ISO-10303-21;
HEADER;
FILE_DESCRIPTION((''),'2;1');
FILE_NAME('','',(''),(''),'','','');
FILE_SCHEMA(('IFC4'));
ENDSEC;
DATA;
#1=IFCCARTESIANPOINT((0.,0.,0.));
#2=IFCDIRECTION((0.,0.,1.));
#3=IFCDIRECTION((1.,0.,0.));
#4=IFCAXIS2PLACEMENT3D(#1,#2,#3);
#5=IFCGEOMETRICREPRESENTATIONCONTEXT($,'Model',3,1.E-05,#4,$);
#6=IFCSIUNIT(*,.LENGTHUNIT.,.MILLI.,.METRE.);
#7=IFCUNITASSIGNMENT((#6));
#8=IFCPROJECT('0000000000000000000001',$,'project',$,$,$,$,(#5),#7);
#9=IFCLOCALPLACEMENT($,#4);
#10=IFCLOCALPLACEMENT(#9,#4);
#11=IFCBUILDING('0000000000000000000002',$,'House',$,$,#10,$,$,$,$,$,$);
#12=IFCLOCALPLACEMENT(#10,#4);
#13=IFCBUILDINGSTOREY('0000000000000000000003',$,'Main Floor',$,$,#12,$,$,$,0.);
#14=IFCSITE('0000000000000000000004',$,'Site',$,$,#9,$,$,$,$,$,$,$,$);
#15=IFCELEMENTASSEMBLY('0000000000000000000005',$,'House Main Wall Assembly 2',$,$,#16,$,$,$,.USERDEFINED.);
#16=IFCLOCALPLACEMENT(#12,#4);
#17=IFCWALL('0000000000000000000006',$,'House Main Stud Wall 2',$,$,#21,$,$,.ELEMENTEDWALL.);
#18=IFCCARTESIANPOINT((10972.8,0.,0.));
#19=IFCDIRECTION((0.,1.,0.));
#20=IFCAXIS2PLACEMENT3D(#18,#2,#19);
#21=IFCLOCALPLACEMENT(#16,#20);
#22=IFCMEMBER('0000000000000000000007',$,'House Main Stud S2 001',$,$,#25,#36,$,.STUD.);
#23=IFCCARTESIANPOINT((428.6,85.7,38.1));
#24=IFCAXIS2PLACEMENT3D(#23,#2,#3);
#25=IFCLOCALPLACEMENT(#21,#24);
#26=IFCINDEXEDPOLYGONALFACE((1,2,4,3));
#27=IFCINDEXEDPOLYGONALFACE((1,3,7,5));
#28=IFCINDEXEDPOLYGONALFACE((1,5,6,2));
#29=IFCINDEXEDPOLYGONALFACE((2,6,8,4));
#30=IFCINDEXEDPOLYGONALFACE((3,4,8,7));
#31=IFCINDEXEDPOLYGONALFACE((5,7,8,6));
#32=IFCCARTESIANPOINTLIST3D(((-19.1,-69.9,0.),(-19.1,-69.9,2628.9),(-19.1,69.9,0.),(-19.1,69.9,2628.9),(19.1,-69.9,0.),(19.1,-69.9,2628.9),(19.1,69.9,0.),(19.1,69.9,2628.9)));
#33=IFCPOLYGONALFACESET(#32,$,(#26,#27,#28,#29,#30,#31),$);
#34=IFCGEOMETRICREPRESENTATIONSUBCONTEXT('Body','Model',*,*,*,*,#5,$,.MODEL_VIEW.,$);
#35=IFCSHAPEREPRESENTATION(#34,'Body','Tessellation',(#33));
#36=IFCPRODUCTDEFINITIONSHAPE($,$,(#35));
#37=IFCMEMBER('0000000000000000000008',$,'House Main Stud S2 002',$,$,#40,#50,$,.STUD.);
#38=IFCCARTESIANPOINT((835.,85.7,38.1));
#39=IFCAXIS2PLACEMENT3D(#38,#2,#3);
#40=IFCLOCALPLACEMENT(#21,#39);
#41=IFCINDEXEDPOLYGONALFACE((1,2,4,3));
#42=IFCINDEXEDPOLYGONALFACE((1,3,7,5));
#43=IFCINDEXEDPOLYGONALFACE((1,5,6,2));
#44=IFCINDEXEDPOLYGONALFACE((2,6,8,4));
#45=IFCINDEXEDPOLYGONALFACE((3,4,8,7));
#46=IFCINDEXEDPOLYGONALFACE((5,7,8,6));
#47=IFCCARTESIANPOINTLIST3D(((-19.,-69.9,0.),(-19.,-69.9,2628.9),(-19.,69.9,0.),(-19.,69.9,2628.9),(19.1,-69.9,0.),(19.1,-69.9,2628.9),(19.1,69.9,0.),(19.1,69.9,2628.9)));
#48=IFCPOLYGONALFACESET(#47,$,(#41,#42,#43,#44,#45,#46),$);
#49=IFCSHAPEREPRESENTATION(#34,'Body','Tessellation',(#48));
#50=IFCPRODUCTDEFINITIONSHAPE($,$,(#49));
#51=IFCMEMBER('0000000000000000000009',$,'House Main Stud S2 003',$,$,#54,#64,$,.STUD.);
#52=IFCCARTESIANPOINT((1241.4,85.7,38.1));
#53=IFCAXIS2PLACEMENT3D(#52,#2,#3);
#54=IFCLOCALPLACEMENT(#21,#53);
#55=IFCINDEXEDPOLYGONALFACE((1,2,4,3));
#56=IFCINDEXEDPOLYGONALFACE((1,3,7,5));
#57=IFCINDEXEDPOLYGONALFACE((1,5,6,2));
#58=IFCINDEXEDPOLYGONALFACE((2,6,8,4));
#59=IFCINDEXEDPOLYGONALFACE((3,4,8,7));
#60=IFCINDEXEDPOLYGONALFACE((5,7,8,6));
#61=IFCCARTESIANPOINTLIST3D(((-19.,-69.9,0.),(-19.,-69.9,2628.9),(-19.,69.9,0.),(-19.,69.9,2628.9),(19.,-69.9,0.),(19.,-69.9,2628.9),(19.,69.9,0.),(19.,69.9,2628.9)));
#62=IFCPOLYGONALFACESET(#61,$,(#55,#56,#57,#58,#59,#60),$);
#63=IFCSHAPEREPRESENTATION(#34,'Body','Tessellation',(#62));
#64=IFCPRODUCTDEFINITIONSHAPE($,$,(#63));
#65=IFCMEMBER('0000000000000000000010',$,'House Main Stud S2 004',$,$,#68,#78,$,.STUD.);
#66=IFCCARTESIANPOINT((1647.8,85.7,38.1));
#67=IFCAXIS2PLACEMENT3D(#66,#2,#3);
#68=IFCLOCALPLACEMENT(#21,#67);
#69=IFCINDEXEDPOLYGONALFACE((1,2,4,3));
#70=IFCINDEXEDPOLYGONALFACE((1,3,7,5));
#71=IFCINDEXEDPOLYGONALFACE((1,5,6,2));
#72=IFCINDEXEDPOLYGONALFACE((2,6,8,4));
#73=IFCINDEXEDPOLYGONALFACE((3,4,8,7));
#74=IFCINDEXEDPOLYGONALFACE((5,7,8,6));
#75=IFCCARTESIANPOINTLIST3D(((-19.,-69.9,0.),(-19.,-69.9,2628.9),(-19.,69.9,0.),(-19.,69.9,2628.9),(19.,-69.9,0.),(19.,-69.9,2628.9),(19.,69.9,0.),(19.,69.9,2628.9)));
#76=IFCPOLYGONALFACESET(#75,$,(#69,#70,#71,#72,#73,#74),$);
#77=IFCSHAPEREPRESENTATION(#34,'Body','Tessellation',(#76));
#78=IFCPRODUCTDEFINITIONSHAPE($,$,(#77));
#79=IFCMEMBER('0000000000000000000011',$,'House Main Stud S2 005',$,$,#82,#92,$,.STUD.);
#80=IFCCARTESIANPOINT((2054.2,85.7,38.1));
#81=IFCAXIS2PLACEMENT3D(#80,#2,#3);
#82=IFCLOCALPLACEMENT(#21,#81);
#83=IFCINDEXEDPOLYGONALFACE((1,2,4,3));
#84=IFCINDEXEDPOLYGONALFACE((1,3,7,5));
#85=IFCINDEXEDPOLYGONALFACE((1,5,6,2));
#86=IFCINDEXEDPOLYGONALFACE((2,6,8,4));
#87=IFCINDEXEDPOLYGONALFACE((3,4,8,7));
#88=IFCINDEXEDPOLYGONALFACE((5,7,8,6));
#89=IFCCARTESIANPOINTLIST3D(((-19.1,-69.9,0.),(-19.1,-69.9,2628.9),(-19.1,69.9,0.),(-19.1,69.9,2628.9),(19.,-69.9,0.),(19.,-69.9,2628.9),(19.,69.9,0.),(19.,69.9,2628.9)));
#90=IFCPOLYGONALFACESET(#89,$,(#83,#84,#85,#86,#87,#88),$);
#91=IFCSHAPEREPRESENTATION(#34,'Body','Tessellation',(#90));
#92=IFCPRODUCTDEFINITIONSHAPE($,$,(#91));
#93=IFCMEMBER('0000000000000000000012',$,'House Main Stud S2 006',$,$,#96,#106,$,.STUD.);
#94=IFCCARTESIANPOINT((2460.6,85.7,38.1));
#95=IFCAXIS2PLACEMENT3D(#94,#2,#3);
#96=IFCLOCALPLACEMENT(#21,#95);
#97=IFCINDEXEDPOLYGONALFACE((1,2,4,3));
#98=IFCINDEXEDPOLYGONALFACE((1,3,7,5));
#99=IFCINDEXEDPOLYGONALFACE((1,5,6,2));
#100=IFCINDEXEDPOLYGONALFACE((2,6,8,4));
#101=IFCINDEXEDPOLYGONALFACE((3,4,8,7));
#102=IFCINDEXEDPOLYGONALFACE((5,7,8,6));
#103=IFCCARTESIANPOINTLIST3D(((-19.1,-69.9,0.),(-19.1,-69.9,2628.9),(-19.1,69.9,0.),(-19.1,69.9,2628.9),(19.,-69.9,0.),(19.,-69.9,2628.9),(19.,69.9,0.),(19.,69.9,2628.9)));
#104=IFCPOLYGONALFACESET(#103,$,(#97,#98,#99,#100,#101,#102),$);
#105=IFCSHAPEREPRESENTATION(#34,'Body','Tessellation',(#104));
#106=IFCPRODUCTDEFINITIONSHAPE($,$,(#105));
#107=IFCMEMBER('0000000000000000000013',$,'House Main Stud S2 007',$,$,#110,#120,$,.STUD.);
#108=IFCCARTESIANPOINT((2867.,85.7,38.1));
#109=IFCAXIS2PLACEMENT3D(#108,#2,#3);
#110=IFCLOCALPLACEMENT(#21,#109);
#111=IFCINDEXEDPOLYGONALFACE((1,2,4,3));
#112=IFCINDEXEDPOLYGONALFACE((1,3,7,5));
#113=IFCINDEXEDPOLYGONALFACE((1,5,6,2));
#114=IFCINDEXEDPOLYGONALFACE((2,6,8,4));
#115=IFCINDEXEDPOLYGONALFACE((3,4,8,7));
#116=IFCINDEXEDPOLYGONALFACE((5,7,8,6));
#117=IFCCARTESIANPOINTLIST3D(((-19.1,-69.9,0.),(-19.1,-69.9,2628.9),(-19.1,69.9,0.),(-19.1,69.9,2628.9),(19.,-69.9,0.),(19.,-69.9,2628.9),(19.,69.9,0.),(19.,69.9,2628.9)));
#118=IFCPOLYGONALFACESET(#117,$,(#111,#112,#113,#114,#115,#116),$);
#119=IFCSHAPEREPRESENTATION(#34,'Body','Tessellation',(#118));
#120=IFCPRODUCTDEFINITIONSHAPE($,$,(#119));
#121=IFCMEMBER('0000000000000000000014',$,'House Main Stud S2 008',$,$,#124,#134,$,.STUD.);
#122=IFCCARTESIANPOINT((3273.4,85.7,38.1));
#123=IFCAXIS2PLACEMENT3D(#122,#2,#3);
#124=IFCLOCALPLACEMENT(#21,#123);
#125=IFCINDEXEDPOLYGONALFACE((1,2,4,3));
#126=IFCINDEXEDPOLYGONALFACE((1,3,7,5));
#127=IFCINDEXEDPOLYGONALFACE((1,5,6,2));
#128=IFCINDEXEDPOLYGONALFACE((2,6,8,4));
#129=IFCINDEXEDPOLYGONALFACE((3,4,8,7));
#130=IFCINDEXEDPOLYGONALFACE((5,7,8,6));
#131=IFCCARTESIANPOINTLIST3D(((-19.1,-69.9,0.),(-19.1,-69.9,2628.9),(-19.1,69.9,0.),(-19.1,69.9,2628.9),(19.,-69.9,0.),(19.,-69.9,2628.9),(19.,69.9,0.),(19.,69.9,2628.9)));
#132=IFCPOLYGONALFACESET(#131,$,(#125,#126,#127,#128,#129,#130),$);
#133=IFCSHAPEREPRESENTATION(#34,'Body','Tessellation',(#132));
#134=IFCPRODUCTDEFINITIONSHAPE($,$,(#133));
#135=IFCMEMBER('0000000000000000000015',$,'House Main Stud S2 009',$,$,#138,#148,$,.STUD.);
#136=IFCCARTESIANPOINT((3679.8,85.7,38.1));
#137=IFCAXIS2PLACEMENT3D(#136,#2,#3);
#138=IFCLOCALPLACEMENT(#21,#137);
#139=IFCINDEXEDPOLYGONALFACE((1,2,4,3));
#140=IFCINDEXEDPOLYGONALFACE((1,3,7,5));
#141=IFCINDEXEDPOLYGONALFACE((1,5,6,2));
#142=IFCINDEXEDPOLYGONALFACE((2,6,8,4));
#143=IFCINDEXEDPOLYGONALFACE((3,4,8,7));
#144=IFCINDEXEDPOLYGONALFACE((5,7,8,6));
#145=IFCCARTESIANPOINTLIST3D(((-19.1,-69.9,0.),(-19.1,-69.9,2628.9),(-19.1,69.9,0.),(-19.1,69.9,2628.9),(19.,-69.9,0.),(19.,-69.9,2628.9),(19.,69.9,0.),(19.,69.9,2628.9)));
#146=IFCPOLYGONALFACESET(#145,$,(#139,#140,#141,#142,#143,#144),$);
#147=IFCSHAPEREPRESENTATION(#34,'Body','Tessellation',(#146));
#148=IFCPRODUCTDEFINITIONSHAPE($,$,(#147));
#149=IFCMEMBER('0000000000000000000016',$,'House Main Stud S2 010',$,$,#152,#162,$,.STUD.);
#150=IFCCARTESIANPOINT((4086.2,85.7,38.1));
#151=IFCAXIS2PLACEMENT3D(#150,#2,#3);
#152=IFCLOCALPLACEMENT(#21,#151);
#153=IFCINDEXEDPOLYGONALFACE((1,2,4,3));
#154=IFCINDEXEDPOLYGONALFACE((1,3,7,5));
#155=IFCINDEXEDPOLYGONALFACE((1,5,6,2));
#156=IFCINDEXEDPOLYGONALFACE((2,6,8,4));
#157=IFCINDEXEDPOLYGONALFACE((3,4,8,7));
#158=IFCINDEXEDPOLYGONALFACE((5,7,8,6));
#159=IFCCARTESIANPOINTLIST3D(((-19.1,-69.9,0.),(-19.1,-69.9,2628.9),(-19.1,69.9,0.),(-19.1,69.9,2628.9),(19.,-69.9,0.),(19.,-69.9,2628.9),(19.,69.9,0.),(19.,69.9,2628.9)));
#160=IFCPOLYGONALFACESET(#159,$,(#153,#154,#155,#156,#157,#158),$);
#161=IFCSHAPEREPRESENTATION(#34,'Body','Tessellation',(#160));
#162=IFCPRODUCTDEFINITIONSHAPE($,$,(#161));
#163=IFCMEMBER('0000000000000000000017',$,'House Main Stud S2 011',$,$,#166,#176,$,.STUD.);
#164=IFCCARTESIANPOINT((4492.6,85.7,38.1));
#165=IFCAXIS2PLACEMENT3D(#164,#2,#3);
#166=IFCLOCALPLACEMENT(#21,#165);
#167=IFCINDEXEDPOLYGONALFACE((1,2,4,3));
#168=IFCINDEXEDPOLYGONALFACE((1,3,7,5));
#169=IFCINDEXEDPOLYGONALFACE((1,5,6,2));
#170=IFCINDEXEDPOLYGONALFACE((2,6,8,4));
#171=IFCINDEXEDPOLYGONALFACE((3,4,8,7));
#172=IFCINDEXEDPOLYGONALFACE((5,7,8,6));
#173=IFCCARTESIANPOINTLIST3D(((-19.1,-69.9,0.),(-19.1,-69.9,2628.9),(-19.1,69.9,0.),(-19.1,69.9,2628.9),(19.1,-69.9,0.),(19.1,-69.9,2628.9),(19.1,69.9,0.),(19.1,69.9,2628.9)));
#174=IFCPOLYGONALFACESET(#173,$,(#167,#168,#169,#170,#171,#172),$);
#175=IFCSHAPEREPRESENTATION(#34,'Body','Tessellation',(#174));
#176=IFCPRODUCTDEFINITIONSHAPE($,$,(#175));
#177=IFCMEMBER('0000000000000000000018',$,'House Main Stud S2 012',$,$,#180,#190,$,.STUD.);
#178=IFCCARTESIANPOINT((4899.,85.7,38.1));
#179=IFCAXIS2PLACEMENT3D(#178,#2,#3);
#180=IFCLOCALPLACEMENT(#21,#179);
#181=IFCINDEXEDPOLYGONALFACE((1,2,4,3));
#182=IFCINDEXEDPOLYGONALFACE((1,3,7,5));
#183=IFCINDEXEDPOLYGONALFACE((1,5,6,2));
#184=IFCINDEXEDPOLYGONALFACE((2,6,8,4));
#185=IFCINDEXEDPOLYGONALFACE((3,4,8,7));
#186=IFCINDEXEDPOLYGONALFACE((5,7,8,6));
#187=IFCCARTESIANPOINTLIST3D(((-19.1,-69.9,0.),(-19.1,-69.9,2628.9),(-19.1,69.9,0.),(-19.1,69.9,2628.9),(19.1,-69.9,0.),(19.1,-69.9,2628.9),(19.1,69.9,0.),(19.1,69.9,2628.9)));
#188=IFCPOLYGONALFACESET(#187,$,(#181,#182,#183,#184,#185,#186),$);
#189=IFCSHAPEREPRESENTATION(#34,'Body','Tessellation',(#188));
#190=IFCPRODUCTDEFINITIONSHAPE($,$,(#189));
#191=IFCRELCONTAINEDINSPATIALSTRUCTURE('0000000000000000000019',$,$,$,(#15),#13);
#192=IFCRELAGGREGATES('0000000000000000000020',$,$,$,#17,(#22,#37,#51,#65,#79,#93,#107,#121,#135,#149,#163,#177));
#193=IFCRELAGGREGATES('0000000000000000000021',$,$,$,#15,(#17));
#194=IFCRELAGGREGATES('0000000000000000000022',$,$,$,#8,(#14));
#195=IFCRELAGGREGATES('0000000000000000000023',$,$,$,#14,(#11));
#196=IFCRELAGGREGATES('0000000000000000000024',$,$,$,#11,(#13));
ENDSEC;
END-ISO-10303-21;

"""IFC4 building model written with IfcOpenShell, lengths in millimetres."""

from ifc_helpers import new_model, si_unit, frame, origin_with_axes, origin_2d, place, context, subcontext, project, spatial, rectangle, extrude, element, aggregate, save


model = new_model("IFC4")

# Units and contexts
model_context = context("Model", 3, precision=1e-05, world=origin_with_axes())
body_context = subcontext(model_context, "Body", "Model", "MODEL_VIEW")
ifc_project = project(units=[si_unit("LENGTHUNIT", "METRE", prefix="MILLI")], contexts=[model_context])

# Site, building, storey
site_placement = place(None, origin_with_axes())
site = spatial("IfcSite", under=ifc_project, at=site_placement, Name="Site")
building_placement = place(site_placement, origin_with_axes())
building = spatial("IfcBuilding", under=site, at=building_placement, Name="House")
storey_placement = place(building_placement, origin_with_axes())
storey = spatial("IfcBuildingStorey", under=building, at=storey_placement, Name="Main Floor", Elevation=0.0)

# Element assembly, wall, members
assembly_1_placement = place(storey_placement, origin_with_axes())
assembly_1 = element("IfcElementAssembly", 1, at=assembly_1_placement, inside=storey, Name="House Main Wall Assembly 2", PredefinedType="USERDEFINED")
wall_1_placement = place(assembly_1_placement, frame((10972.8, 0.0, 0.0), z_axis=(0.0, 0.0, 1.0), x_axis=(0.0, 1.0, 0.0)))
wall_1 = element("IfcWall", 2, at=wall_1_placement, Name="House Main Stud Wall 2", PredefinedType="ELEMENTEDWALL")
member_1_placement = place(wall_1_placement, frame((428.6, 85.7, 38.1), z_axis=(0.0, 0.0, 1.0), x_axis=(1.0, 0.0, 0.0)))
member_1 = element("IfcMember", 3, at=member_1_placement, Name="House Main Stud S2 001", PredefinedType="STUD", context=body_context, shape_type="SweptSolid", body=[
    extrude(rectangle(XDim=38.1, YDim=139.7, at=origin_2d()), origin_with_axes(), (0.0, 0.0, 1.0), 2628.9),
])
member_2_placement = place(wall_1_placement, frame((835.0, 85.7, 38.1), z_axis=(0.0, 0.0, 1.0), x_axis=(1.0, 0.0, 0.0)))
member_2 = element("IfcMember", 4, at=member_2_placement, Name="House Main Stud S2 002", PredefinedType="STUD", context=body_context, shape_type="SweptSolid", body=[
    extrude(rectangle(XDim=38.1, YDim=139.7, at=origin_2d()), origin_with_axes(), (0.0, 0.0, 1.0), 2628.9),
])
member_3_placement = place(wall_1_placement, frame((1241.4, 85.7, 38.1), z_axis=(0.0, 0.0, 1.0), x_axis=(1.0, 0.0, 0.0)))
member_3 = element("IfcMember", 5, at=member_3_placement, Name="House Main Stud S2 003", PredefinedType="STUD", context=body_context, shape_type="SweptSolid", body=[
    extrude(rectangle(XDim=38.1, YDim=139.7, at=origin_2d()), origin_with_axes(), (0.0, 0.0, 1.0), 2628.9),
])
member_4_placement = place(wall_1_placement, frame((1647.8, 85.7, 38.1), z_axis=(0.0, 0.0, 1.0), x_axis=(1.0, 0.0, 0.0)))
member_4 = element("IfcMember", 6, at=member_4_placement, Name="House Main Stud S2 004", PredefinedType="STUD", context=body_context, shape_type="SweptSolid", body=[
    extrude(rectangle(XDim=38.1, YDim=139.7, at=origin_2d()), origin_with_axes(), (0.0, 0.0, 1.0), 2628.9),
])
member_5_placement = place(wall_1_placement, frame((2054.2, 85.7, 38.1), z_axis=(0.0, 0.0, 1.0), x_axis=(1.0, 0.0, 0.0)))
member_5 = element("IfcMember", 7, at=member_5_placement, Name="House Main Stud S2 005", PredefinedType="STUD", context=body_context, shape_type="SweptSolid", body=[
    extrude(rectangle(XDim=38.1, YDim=139.7, at=origin_2d()), origin_with_axes(), (0.0, 0.0, 1.0), 2628.9),
])
member_6_placement = place(wall_1_placement, frame((2460.6, 85.7, 38.1), z_axis=(0.0, 0.0, 1.0), x_axis=(1.0, 0.0, 0.0)))
member_6 = element("IfcMember", 8, at=member_6_placement, Name="House Main Stud S2 006", PredefinedType="STUD", context=body_context, shape_type="SweptSolid", body=[
    extrude(rectangle(XDim=38.1, YDim=139.7, at=origin_2d()), origin_with_axes(), (0.0, 0.0, 1.0), 2628.9),
])
member_7_placement = place(wall_1_placement, frame((2867.0, 85.7, 38.1), z_axis=(0.0, 0.0, 1.0), x_axis=(1.0, 0.0, 0.0)))
member_7 = element("IfcMember", 9, at=member_7_placement, Name="House Main Stud S2 007", PredefinedType="STUD", context=body_context, shape_type="SweptSolid", body=[
    extrude(rectangle(XDim=38.1, YDim=139.7, at=origin_2d()), origin_with_axes(), (0.0, 0.0, 1.0), 2628.9),
])
member_8_placement = place(wall_1_placement, frame((3273.4, 85.7, 38.1), z_axis=(0.0, 0.0, 1.0), x_axis=(1.0, 0.0, 0.0)))
member_8 = element("IfcMember", 10, at=member_8_placement, Name="House Main Stud S2 008", PredefinedType="STUD", context=body_context, shape_type="SweptSolid", body=[
    extrude(rectangle(XDim=38.1, YDim=139.7, at=origin_2d()), origin_with_axes(), (0.0, 0.0, 1.0), 2628.9),
])
member_9_placement = place(wall_1_placement, frame((3679.8, 85.7, 38.1), z_axis=(0.0, 0.0, 1.0), x_axis=(1.0, 0.0, 0.0)))
member_9 = element("IfcMember", 11, at=member_9_placement, Name="House Main Stud S2 009", PredefinedType="STUD", context=body_context, shape_type="SweptSolid", body=[
    extrude(rectangle(XDim=38.1, YDim=139.7, at=origin_2d()), origin_with_axes(), (0.0, 0.0, 1.0), 2628.9),
])
member_10_placement = place(wall_1_placement, frame((4086.2, 85.7, 38.1), z_axis=(0.0, 0.0, 1.0), x_axis=(1.0, 0.0, 0.0)))
member_10 = element("IfcMember", 12, at=member_10_placement, Name="House Main Stud S2 010", PredefinedType="STUD", context=body_context, shape_type="SweptSolid", body=[
    extrude(rectangle(XDim=38.1, YDim=139.7, at=origin_2d()), origin_with_axes(), (0.0, 0.0, 1.0), 2628.9),
])
member_11_placement = place(wall_1_placement, frame((4492.6, 85.7, 38.1), z_axis=(0.0, 0.0, 1.0), x_axis=(1.0, 0.0, 0.0)))
member_11 = element("IfcMember", 13, at=member_11_placement, Name="House Main Stud S2 011", PredefinedType="STUD", context=body_context, shape_type="SweptSolid", body=[
    extrude(rectangle(XDim=38.1, YDim=139.7, at=origin_2d()), origin_with_axes(), (0.0, 0.0, 1.0), 2628.9),
])
member_12_placement = place(wall_1_placement, frame((4899.0, 85.7, 38.1), z_axis=(0.0, 0.0, 1.0), x_axis=(1.0, 0.0, 0.0)))
member_12 = element("IfcMember", 14, at=member_12_placement, Name="House Main Stud S2 012", PredefinedType="STUD", context=body_context, shape_type="SweptSolid", body=[
    extrude(rectangle(XDim=38.1, YDim=139.7, at=origin_2d()), origin_with_axes(), (0.0, 0.0, 1.0), 2628.9),
])
aggregate(wall_1, [member_1, member_2, member_3, member_4, member_5, member_6, member_7, member_8, member_9, member_10, member_11, member_12])
aggregate(assembly_1, [wall_1])

save(model, "model.ifc")
